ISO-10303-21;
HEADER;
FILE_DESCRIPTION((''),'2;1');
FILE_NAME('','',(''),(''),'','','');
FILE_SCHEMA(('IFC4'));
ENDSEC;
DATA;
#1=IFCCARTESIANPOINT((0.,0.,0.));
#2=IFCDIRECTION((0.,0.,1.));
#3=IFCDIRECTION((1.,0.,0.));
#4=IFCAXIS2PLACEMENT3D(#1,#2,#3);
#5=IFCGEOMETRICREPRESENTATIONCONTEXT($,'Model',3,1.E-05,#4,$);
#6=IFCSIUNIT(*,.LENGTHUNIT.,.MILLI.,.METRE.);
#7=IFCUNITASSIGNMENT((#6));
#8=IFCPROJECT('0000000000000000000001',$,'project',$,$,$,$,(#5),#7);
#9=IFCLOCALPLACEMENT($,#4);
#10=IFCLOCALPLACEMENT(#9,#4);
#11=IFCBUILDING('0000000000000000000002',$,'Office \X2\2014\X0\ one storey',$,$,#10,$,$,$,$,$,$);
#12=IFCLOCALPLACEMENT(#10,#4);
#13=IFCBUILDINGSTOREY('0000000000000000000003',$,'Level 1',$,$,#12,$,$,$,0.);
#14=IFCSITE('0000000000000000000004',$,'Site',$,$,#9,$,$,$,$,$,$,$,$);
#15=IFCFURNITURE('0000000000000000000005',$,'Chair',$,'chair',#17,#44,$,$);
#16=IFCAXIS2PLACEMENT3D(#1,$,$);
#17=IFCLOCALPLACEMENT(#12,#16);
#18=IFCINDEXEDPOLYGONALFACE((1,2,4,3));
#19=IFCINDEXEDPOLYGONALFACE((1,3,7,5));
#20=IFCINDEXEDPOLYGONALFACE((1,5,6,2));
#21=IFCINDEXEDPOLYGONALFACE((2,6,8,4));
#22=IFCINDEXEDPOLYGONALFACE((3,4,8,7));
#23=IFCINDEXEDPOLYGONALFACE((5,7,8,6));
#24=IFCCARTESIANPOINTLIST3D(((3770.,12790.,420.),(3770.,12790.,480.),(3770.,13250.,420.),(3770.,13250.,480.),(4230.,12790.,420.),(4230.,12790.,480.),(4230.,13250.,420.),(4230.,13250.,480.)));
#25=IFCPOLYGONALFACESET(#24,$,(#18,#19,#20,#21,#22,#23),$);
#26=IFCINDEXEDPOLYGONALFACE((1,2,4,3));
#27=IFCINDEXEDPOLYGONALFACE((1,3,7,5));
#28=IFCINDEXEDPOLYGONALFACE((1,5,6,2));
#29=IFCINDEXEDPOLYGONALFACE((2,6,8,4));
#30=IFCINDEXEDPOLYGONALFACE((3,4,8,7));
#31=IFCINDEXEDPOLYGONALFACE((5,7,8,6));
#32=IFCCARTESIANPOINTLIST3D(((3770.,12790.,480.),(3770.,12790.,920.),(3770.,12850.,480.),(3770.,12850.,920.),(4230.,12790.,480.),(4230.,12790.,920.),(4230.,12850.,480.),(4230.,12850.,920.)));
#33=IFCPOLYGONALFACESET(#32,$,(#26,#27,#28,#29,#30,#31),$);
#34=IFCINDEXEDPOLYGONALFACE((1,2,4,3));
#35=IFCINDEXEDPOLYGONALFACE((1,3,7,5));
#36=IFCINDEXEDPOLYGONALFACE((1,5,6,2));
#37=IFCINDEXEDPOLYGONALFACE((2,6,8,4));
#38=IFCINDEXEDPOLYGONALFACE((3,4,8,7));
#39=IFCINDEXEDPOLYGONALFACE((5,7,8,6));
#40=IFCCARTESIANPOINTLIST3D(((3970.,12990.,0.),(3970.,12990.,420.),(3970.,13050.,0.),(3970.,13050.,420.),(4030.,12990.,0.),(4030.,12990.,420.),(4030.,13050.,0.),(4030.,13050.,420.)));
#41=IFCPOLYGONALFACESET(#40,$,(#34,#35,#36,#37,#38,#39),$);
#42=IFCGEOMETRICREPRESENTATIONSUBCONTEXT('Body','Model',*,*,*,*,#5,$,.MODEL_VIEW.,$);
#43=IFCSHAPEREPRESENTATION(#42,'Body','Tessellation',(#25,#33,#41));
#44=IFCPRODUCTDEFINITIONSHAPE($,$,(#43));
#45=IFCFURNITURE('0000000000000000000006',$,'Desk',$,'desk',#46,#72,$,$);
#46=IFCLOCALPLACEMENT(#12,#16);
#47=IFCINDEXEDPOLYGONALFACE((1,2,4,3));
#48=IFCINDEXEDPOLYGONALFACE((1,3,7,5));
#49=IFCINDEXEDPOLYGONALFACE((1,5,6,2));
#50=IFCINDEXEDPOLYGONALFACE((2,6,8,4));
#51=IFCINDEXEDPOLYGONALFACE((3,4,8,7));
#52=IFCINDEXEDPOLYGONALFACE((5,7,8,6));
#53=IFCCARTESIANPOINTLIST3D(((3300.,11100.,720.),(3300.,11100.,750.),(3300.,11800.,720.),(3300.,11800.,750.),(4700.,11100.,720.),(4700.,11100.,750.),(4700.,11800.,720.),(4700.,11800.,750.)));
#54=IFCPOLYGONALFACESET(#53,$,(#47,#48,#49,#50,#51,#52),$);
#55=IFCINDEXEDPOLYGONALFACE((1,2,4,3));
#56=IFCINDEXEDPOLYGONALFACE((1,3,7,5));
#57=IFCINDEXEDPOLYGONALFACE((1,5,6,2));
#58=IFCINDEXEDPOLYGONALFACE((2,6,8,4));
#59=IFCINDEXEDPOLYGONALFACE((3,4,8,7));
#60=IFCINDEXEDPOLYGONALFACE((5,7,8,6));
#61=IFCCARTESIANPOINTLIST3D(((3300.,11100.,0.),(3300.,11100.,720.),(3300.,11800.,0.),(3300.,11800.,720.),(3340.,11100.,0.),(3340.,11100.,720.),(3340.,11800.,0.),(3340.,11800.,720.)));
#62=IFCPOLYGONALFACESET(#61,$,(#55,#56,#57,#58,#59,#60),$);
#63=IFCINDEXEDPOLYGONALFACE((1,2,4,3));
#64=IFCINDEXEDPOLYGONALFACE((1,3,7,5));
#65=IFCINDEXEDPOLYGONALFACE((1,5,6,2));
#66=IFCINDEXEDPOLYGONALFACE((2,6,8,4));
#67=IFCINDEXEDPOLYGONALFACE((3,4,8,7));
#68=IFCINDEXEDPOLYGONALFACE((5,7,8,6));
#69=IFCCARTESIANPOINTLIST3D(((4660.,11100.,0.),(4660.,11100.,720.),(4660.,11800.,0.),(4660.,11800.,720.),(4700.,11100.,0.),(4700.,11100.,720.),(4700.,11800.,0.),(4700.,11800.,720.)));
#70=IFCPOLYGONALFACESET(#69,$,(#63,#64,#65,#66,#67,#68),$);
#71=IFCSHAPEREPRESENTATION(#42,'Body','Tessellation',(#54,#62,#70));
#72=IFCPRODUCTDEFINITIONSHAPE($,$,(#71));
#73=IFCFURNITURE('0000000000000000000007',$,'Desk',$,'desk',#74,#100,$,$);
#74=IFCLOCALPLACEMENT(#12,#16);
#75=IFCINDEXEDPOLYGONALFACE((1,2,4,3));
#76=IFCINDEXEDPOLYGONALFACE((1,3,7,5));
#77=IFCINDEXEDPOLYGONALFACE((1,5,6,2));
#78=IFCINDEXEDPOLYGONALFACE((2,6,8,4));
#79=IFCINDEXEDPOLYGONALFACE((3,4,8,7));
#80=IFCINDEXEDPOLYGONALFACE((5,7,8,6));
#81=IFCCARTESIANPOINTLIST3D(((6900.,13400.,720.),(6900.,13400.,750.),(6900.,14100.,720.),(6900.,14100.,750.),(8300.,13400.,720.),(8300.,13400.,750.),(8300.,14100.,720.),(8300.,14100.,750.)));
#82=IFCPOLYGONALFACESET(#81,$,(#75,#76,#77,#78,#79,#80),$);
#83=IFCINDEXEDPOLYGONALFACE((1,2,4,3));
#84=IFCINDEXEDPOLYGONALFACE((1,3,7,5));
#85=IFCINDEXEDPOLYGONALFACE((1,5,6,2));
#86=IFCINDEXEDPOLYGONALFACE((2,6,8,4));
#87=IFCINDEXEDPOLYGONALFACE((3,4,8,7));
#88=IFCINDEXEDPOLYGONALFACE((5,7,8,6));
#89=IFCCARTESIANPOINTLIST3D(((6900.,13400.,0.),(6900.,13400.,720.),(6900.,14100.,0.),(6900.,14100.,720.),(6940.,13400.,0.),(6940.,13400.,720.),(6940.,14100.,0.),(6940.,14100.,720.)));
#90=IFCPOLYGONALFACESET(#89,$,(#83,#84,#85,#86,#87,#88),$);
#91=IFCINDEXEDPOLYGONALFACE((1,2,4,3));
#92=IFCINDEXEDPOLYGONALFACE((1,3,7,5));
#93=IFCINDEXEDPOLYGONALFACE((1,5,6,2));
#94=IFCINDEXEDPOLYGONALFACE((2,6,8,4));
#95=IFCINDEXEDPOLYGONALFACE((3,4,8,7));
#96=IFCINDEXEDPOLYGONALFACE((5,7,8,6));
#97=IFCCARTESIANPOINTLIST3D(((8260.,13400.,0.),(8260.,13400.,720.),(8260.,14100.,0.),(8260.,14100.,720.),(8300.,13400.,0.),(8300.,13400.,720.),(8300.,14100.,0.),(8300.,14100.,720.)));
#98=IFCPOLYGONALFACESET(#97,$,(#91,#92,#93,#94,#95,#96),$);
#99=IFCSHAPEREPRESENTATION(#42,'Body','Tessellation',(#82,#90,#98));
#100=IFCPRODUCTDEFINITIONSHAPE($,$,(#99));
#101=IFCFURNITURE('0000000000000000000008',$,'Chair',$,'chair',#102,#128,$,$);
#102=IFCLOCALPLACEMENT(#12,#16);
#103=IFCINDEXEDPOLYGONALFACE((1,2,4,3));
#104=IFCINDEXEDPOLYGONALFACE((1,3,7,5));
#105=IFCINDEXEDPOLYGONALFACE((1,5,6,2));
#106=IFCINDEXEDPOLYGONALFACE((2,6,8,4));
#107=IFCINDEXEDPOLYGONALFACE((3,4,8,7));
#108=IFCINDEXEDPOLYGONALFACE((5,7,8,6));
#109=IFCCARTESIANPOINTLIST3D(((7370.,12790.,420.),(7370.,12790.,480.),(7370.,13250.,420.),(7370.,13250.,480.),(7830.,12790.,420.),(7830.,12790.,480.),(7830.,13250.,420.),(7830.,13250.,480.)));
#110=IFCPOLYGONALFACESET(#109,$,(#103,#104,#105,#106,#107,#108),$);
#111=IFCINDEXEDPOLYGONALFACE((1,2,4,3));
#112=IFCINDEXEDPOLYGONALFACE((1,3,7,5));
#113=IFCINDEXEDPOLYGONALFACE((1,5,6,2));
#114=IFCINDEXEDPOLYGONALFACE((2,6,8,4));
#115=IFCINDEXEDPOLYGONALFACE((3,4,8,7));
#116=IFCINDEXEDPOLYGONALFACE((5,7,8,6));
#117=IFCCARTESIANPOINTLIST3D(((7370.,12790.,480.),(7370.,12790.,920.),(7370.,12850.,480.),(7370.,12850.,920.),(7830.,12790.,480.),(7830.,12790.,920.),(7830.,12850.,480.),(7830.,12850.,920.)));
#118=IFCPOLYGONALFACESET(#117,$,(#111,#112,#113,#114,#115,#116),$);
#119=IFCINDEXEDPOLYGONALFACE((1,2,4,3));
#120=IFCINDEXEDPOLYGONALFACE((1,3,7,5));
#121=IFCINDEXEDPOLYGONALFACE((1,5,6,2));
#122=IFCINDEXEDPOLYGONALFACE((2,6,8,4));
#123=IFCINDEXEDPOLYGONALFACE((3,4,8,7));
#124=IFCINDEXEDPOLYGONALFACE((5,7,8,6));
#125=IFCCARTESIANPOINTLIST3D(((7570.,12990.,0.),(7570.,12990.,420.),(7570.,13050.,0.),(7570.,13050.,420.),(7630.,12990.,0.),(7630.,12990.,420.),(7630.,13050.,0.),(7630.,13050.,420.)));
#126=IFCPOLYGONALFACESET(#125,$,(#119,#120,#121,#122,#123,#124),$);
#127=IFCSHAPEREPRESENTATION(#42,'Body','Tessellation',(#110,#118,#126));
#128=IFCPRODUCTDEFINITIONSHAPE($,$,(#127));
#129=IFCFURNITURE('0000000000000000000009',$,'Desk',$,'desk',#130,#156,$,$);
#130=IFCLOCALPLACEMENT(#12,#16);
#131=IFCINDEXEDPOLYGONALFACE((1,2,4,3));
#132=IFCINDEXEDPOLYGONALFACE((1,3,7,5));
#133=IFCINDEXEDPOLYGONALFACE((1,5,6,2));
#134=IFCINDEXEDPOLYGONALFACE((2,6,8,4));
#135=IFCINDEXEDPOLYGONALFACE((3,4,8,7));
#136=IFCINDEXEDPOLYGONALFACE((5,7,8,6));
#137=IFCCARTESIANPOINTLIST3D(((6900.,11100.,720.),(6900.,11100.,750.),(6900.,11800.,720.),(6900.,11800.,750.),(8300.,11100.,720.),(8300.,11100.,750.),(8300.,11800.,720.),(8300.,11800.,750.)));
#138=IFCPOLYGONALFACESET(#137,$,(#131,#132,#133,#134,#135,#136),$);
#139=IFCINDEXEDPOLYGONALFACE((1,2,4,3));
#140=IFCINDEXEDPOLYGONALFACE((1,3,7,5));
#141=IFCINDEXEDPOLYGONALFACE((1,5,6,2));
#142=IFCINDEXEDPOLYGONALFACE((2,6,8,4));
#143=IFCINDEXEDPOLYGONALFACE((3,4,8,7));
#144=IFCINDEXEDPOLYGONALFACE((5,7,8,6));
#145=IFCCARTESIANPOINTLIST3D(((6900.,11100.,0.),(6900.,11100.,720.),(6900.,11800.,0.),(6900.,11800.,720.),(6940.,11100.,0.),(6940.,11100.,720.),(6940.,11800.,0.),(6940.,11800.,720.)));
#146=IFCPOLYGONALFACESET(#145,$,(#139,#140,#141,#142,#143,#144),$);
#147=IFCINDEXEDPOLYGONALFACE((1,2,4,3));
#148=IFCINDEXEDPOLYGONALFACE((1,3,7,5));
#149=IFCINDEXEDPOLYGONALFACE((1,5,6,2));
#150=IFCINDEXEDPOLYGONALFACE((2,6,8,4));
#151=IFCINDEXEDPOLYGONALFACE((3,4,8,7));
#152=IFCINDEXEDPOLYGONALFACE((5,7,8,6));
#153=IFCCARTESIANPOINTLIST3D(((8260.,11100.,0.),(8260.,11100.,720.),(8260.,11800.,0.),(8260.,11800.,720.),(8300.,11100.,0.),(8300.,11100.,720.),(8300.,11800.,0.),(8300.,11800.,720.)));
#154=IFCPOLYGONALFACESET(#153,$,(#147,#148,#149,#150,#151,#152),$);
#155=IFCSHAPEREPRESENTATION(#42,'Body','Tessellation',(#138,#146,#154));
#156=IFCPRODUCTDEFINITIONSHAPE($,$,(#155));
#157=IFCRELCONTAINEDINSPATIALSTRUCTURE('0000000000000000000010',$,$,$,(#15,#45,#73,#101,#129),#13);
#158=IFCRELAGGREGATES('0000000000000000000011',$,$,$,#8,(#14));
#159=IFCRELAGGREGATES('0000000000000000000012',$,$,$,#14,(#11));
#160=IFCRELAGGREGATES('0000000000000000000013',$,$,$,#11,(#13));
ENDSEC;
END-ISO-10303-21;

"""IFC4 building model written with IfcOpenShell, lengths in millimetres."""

from ifc_helpers import new_model, si_unit, frame, frame_2d, origin, origin_with_axes, place, context, subcontext, project, spatial, rectangle, extrude, element, save


model = new_model("IFC4")

# Units and contexts
model_context = context("Model", 3, precision=1e-05, world=origin_with_axes())
body_context = subcontext(model_context, "Body", "Model", "MODEL_VIEW")
ifc_project = project(units=[si_unit("LENGTHUNIT", "METRE", prefix="MILLI")], contexts=[model_context])

# Site, building, storey
site_placement = place(None, origin_with_axes())
site = spatial("IfcSite", under=ifc_project, at=site_placement, Name="Site")
building_placement = place(site_placement, origin_with_axes())
building = spatial("IfcBuilding", under=site, at=building_placement, Name="Office — one storey")
storey_placement = place(building_placement, origin_with_axes())
storey = spatial("IfcBuildingStorey", under=building, at=storey_placement, Name="Level 1", Elevation=0.0)

# Furniture
furniture_1_placement = place(storey_placement, frame((3770.0, 12790.0, 0.0), z_axis=(0.0, 0.0, 1.0), x_axis=(1.0, 0.0, 0.0)))
element("IfcFurniture", 1, at=furniture_1_placement, inside=storey, Name="Chair", ObjectType="chair", context=body_context, shape_type="SweptSolid", body=[
    extrude(rectangle(XDim=460.0, YDim=460.0, at=frame_2d((230.0, 230.0))), frame((0.0, 0.0, 420.0)), (0.0, 0.0, 1.0), 60.0),
    extrude(rectangle(XDim=460.0, YDim=60.0, at=frame_2d((230.0, 30.0))), frame((0.0, 0.0, 480.0)), (0.0, 0.0, 1.0), 440.0),
    extrude(rectangle(XDim=60.0, YDim=60.0, at=frame_2d((230.0, 230.0))), origin(), (0.0, 0.0, 1.0), 420.0),
])
for number, where, z_axis, x_axis, name in (
    (2, (3300.0, 11100.0, 0.0), (0.0, 0.0, 1.0), (1.0, 0.0, 0.0), "Desk"),
    (3, (6900.0, 13400.0, 0.0), (0.0, 0.0, 1.0), (1.0, 0.0, 0.0), "Desk"),
):
    element("IfcFurniture", number, at=place(storey_placement, frame(where, z_axis=z_axis, x_axis=x_axis)), inside=storey, Name=name, ObjectType="desk", context=body_context, shape_type="SweptSolid", body=[
        extrude(rectangle(XDim=1400.0, YDim=700.0, at=frame_2d((700.0, 350.0))), frame((0.0, 0.0, 720.0)), (0.0, 0.0, 1.0), 30.0),
        extrude(rectangle(XDim=40.0, YDim=700.0, at=frame_2d((20.0, 350.0))), origin(), (0.0, 0.0, 1.0), 720.0),
        extrude(rectangle(XDim=40.0, YDim=700.0, at=frame_2d((1380.0, 350.0))), origin(), (0.0, 0.0, 1.0), 720.0),
    ])
furniture_2_placement = place(storey_placement, frame((7370.0, 12790.0, 0.0), z_axis=(0.0, 0.0, 1.0), x_axis=(1.0, 0.0, 0.0)))
element("IfcFurniture", 4, at=furniture_2_placement, inside=storey, Name="Chair", ObjectType="chair", context=body_context, shape_type="SweptSolid", body=[
    extrude(rectangle(XDim=460.0, YDim=460.0, at=frame_2d((230.0, 230.0))), frame((0.0, 0.0, 420.0)), (0.0, 0.0, 1.0), 60.0),
    extrude(rectangle(XDim=460.0, YDim=60.0, at=frame_2d((230.0, 30.0))), frame((0.0, 0.0, 480.0)), (0.0, 0.0, 1.0), 440.0),
    extrude(rectangle(XDim=60.0, YDim=60.0, at=frame_2d((230.0, 230.0))), origin(), (0.0, 0.0, 1.0), 420.0),
])
furniture_3_placement = place(storey_placement, frame((6900.0, 11100.0, 0.0), z_axis=(0.0, 0.0, 1.0), x_axis=(1.0, 0.0, 0.0)))
element("IfcFurniture", 5, at=furniture_3_placement, inside=storey, Name="Desk", ObjectType="desk", context=body_context, shape_type="SweptSolid", body=[
    extrude(rectangle(XDim=1400.0, YDim=700.0, at=frame_2d((700.0, 350.0))), frame((0.0, 0.0, 720.0)), (0.0, 0.0, 1.0), 30.0),
    extrude(rectangle(XDim=40.0, YDim=700.0, at=frame_2d((20.0, 350.0))), origin(), (0.0, 0.0, 1.0), 720.0),
    extrude(rectangle(XDim=40.0, YDim=700.0, at=frame_2d((1380.0, 350.0))), origin(), (0.0, 0.0, 1.0), 720.0),
])

save(model, "model.ifc")
